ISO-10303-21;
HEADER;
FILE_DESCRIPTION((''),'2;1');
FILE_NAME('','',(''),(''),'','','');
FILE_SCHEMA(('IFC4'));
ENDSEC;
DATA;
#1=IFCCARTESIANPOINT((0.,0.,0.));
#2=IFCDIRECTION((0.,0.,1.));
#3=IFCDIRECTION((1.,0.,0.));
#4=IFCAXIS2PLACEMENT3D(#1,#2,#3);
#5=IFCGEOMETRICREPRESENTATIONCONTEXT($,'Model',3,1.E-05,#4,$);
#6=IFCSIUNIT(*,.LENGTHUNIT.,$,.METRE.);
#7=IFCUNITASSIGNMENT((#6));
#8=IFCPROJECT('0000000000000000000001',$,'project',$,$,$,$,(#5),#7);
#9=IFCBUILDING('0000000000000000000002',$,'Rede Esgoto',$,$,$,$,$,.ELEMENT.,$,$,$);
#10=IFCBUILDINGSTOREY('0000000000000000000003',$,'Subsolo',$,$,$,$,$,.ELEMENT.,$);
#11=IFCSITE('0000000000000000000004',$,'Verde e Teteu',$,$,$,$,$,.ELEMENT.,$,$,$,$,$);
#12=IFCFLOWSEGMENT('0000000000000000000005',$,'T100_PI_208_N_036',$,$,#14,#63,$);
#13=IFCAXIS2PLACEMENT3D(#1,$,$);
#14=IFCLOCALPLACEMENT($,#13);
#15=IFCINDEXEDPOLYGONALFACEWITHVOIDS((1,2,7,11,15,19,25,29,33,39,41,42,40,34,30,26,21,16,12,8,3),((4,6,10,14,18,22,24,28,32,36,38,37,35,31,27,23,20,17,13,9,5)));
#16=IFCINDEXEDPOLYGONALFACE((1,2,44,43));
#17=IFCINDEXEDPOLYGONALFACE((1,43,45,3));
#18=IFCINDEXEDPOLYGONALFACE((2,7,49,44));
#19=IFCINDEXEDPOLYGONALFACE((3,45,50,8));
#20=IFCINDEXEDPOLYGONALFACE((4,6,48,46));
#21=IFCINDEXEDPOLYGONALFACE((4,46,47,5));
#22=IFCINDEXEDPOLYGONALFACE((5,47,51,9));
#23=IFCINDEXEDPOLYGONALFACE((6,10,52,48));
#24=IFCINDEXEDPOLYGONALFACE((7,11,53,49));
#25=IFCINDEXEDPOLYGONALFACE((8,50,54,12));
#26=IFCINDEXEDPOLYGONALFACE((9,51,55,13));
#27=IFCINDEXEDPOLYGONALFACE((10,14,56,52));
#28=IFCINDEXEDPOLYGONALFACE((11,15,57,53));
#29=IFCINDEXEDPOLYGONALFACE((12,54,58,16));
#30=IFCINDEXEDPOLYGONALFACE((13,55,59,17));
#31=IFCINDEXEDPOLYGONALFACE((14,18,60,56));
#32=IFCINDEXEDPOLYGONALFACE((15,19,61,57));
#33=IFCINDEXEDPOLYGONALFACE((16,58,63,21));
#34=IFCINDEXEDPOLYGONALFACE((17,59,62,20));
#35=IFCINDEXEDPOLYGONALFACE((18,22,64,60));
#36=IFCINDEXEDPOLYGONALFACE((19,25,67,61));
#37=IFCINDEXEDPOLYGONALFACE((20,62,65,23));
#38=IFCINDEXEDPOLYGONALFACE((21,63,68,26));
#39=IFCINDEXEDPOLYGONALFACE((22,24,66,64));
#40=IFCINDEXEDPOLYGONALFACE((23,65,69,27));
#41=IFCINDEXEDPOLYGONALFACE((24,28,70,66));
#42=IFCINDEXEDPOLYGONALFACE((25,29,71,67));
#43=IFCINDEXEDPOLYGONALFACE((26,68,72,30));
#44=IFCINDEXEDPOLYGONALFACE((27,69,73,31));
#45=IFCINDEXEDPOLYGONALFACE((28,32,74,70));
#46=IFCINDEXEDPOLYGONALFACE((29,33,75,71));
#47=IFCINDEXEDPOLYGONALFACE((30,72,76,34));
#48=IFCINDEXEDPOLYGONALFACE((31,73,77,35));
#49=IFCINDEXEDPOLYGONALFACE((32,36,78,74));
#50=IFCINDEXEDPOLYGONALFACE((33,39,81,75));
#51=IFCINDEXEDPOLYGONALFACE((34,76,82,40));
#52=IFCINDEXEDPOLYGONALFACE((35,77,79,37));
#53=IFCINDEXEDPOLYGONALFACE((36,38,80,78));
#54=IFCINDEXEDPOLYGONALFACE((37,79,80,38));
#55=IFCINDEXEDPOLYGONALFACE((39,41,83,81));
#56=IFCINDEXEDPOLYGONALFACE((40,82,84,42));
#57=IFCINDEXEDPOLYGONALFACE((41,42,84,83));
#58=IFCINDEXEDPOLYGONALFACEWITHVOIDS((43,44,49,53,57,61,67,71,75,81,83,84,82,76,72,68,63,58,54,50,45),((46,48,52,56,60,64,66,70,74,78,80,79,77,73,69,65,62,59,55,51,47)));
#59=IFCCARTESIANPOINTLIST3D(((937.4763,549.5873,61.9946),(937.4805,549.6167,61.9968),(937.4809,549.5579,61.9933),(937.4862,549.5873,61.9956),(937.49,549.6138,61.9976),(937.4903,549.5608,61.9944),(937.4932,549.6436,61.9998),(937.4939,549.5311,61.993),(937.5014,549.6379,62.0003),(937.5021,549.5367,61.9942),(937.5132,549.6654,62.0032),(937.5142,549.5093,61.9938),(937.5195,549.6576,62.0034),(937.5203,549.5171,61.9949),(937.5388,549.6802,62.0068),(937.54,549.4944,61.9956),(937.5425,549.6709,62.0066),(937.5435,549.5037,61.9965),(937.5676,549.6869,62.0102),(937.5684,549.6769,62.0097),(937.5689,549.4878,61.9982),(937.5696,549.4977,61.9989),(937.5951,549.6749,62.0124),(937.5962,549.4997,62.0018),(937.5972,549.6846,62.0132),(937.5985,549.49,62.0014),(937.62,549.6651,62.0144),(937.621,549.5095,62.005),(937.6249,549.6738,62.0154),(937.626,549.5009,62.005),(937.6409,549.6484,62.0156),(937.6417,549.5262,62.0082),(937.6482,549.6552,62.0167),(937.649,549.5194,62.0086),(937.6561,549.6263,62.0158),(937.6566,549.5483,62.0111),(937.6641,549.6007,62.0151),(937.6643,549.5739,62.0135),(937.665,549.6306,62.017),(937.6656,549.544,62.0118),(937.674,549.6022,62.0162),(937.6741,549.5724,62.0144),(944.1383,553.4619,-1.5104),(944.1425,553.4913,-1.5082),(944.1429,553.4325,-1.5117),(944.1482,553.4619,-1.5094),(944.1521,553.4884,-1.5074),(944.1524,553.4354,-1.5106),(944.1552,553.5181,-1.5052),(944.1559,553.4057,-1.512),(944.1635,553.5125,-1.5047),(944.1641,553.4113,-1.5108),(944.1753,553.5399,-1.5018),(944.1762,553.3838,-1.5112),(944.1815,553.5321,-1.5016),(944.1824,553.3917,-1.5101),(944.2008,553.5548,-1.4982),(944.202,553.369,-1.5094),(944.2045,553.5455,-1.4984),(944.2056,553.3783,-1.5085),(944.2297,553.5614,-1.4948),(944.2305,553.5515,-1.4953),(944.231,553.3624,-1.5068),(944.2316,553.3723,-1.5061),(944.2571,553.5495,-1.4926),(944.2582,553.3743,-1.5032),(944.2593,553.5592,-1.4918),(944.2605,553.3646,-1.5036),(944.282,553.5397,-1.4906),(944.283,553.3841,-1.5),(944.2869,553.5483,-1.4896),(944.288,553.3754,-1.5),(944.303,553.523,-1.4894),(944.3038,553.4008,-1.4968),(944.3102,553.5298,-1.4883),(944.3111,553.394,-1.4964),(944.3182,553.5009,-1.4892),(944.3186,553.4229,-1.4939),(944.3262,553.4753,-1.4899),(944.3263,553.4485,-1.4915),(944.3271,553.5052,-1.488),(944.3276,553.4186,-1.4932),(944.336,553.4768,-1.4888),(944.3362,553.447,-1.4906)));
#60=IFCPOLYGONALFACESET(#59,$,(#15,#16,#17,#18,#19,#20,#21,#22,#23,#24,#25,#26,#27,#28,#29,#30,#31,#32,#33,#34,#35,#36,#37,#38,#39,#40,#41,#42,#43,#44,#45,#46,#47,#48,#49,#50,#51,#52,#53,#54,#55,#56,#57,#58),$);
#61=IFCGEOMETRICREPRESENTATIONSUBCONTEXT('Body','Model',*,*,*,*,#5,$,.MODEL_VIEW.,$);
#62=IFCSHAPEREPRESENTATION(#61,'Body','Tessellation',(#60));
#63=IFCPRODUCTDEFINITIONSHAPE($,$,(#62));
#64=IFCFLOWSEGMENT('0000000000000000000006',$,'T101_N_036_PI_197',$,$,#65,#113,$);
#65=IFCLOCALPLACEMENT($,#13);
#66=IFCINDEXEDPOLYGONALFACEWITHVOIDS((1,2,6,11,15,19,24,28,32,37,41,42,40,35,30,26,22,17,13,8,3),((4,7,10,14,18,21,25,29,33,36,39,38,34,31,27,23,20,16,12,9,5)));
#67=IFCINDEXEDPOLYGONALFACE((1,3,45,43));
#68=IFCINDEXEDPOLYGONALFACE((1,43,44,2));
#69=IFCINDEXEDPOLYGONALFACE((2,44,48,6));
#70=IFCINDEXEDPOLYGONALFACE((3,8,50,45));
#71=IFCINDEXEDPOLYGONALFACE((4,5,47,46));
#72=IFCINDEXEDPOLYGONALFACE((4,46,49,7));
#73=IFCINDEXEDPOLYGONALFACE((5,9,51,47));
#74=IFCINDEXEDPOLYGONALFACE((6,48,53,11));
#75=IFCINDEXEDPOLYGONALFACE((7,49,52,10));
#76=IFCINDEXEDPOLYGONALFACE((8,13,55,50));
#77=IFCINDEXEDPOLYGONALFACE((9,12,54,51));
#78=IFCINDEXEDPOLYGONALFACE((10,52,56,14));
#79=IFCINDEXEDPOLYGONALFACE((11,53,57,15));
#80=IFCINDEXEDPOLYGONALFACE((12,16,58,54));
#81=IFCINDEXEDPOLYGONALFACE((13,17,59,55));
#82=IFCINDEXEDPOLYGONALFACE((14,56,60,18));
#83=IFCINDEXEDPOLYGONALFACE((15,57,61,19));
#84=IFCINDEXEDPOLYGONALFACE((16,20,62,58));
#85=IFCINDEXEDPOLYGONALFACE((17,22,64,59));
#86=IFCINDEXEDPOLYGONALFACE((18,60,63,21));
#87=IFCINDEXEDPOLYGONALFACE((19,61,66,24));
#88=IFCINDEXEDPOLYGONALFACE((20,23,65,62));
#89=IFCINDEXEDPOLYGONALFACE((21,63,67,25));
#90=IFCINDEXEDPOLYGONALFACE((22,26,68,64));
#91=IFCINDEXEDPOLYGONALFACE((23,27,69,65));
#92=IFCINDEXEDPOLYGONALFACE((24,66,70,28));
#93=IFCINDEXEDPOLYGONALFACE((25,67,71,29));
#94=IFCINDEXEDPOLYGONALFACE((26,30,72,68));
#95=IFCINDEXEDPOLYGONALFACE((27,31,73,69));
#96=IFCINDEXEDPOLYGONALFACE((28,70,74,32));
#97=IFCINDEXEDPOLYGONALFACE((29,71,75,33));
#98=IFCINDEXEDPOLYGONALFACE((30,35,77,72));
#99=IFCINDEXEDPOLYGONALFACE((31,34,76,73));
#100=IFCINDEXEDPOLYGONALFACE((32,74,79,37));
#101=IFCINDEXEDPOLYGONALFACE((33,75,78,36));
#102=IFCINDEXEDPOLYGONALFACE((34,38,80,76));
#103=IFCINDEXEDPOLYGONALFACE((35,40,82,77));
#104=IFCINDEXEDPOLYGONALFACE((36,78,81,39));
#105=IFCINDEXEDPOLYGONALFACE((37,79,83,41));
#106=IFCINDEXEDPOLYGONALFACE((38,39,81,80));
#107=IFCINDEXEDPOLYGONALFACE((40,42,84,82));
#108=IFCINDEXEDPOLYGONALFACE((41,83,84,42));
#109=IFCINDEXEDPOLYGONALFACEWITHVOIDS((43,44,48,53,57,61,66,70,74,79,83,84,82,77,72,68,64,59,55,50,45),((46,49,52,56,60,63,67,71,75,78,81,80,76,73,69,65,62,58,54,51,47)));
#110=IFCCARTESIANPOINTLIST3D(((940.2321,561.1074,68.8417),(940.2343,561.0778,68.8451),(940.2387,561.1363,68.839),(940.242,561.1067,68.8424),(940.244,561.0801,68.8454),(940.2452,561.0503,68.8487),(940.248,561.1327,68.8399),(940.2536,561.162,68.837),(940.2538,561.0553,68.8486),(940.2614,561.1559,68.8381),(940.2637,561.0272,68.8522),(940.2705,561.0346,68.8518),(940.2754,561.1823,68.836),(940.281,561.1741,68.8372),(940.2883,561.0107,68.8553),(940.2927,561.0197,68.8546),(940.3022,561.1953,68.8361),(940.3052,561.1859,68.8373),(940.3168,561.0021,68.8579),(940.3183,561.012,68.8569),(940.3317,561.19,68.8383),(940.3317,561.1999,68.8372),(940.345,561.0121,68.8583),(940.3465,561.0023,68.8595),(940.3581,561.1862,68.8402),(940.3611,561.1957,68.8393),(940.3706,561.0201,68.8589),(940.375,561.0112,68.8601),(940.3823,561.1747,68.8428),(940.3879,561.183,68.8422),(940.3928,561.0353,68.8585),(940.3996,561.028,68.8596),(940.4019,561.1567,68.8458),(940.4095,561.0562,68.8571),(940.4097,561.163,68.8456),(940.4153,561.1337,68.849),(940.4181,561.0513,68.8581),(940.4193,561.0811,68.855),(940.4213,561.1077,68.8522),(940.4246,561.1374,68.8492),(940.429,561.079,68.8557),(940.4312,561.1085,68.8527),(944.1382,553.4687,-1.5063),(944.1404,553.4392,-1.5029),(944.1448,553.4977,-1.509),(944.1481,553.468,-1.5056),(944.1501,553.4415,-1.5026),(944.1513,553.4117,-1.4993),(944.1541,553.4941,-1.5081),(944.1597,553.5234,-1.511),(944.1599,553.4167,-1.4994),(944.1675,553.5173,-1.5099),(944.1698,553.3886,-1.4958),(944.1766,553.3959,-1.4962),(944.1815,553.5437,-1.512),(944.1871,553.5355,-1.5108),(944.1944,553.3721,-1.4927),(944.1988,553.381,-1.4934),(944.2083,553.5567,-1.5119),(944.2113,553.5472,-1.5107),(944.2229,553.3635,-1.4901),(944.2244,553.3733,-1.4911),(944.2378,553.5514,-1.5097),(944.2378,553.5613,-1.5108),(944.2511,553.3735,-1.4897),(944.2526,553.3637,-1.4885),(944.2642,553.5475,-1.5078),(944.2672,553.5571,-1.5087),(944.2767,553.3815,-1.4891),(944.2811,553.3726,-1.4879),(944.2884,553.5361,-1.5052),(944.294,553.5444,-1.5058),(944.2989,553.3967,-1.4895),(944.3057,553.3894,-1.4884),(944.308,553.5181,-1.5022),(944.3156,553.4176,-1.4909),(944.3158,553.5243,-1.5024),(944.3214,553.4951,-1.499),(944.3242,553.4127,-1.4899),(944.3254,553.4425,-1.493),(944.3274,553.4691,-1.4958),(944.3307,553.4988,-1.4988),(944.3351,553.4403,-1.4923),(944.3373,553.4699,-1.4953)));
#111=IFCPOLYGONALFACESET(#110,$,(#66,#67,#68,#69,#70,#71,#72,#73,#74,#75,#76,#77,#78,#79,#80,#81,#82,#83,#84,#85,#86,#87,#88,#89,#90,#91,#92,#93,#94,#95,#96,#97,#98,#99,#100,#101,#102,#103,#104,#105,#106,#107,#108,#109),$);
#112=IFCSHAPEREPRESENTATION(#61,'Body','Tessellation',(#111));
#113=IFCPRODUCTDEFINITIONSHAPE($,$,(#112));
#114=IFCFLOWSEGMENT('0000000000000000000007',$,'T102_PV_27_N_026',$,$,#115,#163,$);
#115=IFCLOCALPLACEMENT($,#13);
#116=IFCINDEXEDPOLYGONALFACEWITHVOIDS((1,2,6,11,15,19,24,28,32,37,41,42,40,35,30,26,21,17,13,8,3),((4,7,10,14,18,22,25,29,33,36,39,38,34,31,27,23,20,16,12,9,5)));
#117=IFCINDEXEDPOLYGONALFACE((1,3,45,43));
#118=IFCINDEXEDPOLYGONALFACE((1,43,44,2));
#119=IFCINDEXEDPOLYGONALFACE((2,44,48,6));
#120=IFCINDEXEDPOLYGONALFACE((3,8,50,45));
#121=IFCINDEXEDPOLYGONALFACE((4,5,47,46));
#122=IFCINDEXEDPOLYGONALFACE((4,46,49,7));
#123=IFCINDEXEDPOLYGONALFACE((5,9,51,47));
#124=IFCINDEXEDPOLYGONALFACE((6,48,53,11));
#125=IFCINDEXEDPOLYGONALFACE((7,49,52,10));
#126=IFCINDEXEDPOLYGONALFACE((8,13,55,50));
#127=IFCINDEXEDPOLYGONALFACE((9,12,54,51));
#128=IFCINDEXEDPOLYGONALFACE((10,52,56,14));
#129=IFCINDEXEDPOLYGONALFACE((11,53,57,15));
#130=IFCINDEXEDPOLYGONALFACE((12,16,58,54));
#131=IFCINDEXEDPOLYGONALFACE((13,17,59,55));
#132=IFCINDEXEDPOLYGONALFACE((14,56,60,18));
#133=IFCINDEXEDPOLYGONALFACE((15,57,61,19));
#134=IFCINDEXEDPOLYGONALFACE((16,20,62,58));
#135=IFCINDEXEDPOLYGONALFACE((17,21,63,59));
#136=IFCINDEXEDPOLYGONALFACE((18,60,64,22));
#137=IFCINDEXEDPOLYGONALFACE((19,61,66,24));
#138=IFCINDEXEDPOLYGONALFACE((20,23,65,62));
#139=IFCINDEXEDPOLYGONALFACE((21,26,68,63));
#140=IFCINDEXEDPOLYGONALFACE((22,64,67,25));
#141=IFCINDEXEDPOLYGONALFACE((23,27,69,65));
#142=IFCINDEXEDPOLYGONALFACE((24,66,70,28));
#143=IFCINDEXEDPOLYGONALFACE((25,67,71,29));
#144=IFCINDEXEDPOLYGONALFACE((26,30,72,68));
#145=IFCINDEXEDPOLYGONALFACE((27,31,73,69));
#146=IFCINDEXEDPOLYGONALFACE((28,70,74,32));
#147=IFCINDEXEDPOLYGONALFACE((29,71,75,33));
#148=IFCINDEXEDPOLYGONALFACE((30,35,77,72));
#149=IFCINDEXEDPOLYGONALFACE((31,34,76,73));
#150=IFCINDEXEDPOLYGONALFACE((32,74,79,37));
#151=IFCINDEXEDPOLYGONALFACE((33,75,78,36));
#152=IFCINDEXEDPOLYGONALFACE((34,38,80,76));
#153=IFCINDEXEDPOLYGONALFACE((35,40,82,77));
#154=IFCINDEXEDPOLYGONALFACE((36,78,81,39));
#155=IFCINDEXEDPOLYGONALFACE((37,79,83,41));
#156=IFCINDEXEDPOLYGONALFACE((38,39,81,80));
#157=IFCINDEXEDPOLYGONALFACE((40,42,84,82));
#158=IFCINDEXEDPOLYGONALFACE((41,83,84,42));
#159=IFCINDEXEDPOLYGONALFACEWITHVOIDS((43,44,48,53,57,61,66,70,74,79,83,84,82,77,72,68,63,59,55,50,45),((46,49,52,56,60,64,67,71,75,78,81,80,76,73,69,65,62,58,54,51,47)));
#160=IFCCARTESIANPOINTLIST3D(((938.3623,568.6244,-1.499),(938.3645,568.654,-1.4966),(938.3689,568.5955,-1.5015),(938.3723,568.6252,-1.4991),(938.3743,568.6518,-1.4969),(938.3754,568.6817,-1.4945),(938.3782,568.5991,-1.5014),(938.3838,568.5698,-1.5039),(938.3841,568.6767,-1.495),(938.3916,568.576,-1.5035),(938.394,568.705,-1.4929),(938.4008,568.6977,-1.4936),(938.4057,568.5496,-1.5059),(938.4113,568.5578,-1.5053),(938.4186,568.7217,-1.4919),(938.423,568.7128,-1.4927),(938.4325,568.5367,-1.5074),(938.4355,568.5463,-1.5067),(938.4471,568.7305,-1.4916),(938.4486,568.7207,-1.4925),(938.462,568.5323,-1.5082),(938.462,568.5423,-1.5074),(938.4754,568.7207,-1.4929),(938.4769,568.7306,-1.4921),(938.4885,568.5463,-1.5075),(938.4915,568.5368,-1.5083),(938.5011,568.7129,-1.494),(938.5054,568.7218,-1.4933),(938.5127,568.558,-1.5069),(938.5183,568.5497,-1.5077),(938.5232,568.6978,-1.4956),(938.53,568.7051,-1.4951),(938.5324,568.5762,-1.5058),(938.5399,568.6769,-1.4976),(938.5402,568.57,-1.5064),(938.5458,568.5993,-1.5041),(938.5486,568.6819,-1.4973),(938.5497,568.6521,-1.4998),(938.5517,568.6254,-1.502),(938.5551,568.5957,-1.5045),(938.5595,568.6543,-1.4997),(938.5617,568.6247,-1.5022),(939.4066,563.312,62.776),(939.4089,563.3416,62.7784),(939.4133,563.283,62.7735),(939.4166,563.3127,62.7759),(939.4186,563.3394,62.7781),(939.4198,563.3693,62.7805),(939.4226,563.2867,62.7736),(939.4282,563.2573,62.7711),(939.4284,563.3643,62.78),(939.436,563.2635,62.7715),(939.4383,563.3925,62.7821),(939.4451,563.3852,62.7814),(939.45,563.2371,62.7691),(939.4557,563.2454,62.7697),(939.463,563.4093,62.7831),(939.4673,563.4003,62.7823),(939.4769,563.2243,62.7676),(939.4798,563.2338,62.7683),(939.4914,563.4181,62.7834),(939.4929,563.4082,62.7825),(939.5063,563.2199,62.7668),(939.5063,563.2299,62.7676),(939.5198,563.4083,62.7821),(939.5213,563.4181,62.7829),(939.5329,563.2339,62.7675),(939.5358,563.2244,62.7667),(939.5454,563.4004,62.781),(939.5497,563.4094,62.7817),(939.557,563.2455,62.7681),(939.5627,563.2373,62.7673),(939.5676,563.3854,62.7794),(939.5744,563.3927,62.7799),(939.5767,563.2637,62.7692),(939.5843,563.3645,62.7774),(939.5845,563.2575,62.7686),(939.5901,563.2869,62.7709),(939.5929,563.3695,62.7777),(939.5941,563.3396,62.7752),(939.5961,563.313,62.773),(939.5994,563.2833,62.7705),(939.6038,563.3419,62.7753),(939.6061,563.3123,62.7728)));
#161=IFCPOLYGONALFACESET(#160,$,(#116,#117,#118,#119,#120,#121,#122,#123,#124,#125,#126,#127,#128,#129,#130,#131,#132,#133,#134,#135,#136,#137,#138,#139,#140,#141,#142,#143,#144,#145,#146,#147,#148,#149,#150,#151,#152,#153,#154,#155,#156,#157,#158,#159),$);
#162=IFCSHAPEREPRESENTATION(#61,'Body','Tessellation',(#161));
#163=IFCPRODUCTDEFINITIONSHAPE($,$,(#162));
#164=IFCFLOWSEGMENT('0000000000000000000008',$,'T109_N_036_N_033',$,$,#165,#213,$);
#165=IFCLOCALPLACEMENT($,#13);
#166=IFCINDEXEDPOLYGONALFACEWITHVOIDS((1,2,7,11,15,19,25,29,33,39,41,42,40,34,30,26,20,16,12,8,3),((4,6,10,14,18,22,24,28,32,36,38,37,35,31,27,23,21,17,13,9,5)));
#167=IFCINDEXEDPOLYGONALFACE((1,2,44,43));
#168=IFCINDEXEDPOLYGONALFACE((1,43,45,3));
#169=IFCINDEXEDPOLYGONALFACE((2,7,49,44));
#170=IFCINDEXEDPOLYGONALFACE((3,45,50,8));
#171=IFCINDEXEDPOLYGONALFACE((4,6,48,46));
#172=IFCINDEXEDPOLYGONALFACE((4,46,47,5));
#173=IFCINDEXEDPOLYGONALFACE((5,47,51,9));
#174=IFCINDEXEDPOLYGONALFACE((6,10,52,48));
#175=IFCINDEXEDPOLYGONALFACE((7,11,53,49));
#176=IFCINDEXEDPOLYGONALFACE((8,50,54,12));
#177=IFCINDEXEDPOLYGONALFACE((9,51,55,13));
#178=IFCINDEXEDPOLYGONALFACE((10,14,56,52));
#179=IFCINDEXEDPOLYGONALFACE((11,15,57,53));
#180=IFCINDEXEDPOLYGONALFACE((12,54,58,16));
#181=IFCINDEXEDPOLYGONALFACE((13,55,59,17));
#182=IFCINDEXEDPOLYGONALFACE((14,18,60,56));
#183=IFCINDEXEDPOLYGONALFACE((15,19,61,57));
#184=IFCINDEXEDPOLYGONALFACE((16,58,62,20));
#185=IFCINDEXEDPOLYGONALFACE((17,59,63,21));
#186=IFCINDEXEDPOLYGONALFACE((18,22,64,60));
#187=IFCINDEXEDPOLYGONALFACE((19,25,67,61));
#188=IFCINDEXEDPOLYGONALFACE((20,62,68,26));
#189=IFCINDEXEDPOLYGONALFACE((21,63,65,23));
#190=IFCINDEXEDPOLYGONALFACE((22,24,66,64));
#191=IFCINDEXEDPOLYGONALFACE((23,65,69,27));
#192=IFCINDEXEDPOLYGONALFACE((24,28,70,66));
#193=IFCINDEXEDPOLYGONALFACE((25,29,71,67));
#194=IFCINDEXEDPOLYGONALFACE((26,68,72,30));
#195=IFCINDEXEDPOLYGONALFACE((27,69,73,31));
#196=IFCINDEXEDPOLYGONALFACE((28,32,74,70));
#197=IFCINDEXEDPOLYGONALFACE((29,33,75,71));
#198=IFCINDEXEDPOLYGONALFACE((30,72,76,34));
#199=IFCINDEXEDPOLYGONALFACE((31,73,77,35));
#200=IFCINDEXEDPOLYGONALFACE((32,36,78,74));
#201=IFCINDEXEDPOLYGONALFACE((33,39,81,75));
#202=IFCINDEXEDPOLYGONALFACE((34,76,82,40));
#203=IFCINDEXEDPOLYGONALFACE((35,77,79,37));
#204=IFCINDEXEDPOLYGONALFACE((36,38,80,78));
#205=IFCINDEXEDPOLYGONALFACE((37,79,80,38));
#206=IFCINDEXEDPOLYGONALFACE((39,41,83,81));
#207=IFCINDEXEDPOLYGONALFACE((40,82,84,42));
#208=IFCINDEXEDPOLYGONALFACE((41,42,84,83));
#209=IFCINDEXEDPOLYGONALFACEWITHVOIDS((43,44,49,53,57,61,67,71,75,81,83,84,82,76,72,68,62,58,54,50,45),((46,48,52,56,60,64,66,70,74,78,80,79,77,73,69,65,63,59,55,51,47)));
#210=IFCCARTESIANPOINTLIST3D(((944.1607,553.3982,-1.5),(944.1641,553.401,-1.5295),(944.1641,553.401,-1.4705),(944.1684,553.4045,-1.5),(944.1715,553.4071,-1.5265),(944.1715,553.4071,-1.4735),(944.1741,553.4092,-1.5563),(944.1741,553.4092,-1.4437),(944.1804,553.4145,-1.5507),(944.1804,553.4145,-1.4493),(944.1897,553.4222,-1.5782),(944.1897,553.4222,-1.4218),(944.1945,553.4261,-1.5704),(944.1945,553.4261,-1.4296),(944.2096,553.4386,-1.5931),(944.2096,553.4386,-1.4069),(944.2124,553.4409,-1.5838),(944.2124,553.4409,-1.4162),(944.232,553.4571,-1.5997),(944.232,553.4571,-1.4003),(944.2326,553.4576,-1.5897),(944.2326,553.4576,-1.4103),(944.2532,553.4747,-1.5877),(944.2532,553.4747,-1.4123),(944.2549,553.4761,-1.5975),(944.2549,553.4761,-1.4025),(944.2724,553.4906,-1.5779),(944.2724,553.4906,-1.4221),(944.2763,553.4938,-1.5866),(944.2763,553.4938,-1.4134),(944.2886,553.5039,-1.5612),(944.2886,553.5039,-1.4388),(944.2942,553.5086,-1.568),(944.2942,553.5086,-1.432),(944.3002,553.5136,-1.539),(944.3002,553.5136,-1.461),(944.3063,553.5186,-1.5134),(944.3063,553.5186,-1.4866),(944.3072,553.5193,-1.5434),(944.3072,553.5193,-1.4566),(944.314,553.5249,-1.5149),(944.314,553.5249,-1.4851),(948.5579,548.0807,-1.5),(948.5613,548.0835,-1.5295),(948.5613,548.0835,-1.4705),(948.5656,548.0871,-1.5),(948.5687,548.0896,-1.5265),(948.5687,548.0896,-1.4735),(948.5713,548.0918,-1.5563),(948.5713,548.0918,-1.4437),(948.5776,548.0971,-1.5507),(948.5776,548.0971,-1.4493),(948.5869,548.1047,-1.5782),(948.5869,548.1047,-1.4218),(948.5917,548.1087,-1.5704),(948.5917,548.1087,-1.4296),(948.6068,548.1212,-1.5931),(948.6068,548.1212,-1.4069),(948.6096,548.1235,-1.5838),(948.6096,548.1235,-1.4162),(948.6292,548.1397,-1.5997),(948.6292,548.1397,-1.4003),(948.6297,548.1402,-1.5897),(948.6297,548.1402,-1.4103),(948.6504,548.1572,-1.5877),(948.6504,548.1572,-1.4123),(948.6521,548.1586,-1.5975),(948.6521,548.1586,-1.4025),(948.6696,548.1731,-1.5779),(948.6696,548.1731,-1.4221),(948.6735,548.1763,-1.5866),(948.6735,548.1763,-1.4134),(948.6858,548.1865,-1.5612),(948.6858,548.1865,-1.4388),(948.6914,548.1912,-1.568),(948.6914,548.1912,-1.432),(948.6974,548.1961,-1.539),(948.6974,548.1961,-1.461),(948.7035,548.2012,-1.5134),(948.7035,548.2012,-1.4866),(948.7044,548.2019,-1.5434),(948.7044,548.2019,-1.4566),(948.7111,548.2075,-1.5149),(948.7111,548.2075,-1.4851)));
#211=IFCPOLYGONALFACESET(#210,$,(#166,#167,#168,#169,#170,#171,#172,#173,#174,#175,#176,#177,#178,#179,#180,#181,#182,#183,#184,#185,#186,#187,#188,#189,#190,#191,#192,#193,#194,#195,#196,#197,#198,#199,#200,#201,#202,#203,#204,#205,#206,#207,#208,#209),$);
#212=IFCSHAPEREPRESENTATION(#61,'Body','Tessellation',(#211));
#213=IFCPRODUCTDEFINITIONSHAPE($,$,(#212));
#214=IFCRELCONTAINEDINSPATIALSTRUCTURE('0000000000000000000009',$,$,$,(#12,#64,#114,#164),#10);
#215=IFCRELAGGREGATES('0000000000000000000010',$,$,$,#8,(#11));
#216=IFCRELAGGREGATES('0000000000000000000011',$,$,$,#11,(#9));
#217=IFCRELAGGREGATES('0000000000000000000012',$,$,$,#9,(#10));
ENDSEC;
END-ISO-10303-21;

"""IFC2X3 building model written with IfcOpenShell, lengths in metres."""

from ifc_helpers import new_model, entity, si_unit, frame, origin_with_axes, place, context, subcontext, project, spatial, element, save


model = new_model("IFC2X3")

# Units and contexts
model_context = context("Model", 3, precision=1e-05, world=origin_with_axes())
body_context = subcontext(model_context, "Body", "Model", "MODEL_VIEW")
ifc_project = project(units=[si_unit("LENGTHUNIT", "METRE")], contexts=[model_context])

# Site, building, storey
site = spatial("IfcSite", under=ifc_project, Name="Verde e Teteu", CompositionType="ELEMENT")
building = spatial("IfcBuilding", under=site, Name="Rede Esgoto", CompositionType="ELEMENT")
storey = spatial("IfcBuildingStorey", under=building, Name="Subsolo", CompositionType="ELEMENT")

# Flow segments
flow_segment_1_placement = place(None, frame((937.5757, 549.5873, 62.005), z_axis=(0.0, 0.0, 1.0), x_axis=(1.0, 0.0, 0.0)))
element("IfcFlowSegment", 1, at=flow_segment_1_placement, inside=storey, Name="T100_PI_208_N_036", context=body_context, shape_type="SweptSolid", body=[
    entity("IfcSweptDiskSolid", entity("IfcPolyline", [entity("IfcCartesianPoint", [0.0, 0.0, 0.0]), entity("IfcCartesianPoint", [6.662, 3.8746, -63.505])]), 0.1, 0.09),
])
flow_segment_2_placement = place(None, frame((944.2378, 553.4619, -1.5), z_axis=(0.0, 0.0, 1.0), x_axis=(1.0, 0.0, 0.0)))
element("IfcFlowSegment", 2, at=flow_segment_2_placement, inside=storey, Name="T101_N_036_PI_197", context=body_context, shape_type="SweptSolid", body=[
    entity("IfcSweptDiskSolid", entity("IfcPolyline", [entity("IfcCartesianPoint", [0.0, 0.0, 0.0]), entity("IfcCartesianPoint", [-3.9061, 7.6386, 70.348])]), 0.1, 0.09),
])
flow_segment_3_placement = place(None, frame((939.5063, 563.3196, 62.775), z_axis=(0.0, 0.0, 1.0), x_axis=(1.0, 0.0, 0.0)))
element("IfcFlowSegment", 3, at=flow_segment_3_placement, inside=storey, Name="T102_PV_27_N_026", context=body_context, shape_type="SweptSolid", body=[
    entity("IfcSweptDiskSolid", entity("IfcPolyline", [entity("IfcCartesianPoint", [0.0, 0.0, 0.0]), entity("IfcCartesianPoint", [-1.0443, 5.3124, -64.275])]), 0.1, 0.09),
])
flow_segment_4_placement = place(None, frame((944.2378, 553.4619, -1.5), z_axis=(0.0, 0.0, 1.0), x_axis=(1.0, 0.0, 0.0)))
element("IfcFlowSegment", 4, at=flow_segment_4_placement, inside=storey, Name="T109_N_036_N_033", context=body_context, shape_type="SweptSolid", body=[
    entity("IfcSweptDiskSolid", entity("IfcPolyline", [entity("IfcCartesianPoint", [0.0, 0.0, 0.0]), entity("IfcCartesianPoint", [4.3972, -5.3174, 0.0])]), 0.1, 0.09),
])

save(model, "model.ifc")
